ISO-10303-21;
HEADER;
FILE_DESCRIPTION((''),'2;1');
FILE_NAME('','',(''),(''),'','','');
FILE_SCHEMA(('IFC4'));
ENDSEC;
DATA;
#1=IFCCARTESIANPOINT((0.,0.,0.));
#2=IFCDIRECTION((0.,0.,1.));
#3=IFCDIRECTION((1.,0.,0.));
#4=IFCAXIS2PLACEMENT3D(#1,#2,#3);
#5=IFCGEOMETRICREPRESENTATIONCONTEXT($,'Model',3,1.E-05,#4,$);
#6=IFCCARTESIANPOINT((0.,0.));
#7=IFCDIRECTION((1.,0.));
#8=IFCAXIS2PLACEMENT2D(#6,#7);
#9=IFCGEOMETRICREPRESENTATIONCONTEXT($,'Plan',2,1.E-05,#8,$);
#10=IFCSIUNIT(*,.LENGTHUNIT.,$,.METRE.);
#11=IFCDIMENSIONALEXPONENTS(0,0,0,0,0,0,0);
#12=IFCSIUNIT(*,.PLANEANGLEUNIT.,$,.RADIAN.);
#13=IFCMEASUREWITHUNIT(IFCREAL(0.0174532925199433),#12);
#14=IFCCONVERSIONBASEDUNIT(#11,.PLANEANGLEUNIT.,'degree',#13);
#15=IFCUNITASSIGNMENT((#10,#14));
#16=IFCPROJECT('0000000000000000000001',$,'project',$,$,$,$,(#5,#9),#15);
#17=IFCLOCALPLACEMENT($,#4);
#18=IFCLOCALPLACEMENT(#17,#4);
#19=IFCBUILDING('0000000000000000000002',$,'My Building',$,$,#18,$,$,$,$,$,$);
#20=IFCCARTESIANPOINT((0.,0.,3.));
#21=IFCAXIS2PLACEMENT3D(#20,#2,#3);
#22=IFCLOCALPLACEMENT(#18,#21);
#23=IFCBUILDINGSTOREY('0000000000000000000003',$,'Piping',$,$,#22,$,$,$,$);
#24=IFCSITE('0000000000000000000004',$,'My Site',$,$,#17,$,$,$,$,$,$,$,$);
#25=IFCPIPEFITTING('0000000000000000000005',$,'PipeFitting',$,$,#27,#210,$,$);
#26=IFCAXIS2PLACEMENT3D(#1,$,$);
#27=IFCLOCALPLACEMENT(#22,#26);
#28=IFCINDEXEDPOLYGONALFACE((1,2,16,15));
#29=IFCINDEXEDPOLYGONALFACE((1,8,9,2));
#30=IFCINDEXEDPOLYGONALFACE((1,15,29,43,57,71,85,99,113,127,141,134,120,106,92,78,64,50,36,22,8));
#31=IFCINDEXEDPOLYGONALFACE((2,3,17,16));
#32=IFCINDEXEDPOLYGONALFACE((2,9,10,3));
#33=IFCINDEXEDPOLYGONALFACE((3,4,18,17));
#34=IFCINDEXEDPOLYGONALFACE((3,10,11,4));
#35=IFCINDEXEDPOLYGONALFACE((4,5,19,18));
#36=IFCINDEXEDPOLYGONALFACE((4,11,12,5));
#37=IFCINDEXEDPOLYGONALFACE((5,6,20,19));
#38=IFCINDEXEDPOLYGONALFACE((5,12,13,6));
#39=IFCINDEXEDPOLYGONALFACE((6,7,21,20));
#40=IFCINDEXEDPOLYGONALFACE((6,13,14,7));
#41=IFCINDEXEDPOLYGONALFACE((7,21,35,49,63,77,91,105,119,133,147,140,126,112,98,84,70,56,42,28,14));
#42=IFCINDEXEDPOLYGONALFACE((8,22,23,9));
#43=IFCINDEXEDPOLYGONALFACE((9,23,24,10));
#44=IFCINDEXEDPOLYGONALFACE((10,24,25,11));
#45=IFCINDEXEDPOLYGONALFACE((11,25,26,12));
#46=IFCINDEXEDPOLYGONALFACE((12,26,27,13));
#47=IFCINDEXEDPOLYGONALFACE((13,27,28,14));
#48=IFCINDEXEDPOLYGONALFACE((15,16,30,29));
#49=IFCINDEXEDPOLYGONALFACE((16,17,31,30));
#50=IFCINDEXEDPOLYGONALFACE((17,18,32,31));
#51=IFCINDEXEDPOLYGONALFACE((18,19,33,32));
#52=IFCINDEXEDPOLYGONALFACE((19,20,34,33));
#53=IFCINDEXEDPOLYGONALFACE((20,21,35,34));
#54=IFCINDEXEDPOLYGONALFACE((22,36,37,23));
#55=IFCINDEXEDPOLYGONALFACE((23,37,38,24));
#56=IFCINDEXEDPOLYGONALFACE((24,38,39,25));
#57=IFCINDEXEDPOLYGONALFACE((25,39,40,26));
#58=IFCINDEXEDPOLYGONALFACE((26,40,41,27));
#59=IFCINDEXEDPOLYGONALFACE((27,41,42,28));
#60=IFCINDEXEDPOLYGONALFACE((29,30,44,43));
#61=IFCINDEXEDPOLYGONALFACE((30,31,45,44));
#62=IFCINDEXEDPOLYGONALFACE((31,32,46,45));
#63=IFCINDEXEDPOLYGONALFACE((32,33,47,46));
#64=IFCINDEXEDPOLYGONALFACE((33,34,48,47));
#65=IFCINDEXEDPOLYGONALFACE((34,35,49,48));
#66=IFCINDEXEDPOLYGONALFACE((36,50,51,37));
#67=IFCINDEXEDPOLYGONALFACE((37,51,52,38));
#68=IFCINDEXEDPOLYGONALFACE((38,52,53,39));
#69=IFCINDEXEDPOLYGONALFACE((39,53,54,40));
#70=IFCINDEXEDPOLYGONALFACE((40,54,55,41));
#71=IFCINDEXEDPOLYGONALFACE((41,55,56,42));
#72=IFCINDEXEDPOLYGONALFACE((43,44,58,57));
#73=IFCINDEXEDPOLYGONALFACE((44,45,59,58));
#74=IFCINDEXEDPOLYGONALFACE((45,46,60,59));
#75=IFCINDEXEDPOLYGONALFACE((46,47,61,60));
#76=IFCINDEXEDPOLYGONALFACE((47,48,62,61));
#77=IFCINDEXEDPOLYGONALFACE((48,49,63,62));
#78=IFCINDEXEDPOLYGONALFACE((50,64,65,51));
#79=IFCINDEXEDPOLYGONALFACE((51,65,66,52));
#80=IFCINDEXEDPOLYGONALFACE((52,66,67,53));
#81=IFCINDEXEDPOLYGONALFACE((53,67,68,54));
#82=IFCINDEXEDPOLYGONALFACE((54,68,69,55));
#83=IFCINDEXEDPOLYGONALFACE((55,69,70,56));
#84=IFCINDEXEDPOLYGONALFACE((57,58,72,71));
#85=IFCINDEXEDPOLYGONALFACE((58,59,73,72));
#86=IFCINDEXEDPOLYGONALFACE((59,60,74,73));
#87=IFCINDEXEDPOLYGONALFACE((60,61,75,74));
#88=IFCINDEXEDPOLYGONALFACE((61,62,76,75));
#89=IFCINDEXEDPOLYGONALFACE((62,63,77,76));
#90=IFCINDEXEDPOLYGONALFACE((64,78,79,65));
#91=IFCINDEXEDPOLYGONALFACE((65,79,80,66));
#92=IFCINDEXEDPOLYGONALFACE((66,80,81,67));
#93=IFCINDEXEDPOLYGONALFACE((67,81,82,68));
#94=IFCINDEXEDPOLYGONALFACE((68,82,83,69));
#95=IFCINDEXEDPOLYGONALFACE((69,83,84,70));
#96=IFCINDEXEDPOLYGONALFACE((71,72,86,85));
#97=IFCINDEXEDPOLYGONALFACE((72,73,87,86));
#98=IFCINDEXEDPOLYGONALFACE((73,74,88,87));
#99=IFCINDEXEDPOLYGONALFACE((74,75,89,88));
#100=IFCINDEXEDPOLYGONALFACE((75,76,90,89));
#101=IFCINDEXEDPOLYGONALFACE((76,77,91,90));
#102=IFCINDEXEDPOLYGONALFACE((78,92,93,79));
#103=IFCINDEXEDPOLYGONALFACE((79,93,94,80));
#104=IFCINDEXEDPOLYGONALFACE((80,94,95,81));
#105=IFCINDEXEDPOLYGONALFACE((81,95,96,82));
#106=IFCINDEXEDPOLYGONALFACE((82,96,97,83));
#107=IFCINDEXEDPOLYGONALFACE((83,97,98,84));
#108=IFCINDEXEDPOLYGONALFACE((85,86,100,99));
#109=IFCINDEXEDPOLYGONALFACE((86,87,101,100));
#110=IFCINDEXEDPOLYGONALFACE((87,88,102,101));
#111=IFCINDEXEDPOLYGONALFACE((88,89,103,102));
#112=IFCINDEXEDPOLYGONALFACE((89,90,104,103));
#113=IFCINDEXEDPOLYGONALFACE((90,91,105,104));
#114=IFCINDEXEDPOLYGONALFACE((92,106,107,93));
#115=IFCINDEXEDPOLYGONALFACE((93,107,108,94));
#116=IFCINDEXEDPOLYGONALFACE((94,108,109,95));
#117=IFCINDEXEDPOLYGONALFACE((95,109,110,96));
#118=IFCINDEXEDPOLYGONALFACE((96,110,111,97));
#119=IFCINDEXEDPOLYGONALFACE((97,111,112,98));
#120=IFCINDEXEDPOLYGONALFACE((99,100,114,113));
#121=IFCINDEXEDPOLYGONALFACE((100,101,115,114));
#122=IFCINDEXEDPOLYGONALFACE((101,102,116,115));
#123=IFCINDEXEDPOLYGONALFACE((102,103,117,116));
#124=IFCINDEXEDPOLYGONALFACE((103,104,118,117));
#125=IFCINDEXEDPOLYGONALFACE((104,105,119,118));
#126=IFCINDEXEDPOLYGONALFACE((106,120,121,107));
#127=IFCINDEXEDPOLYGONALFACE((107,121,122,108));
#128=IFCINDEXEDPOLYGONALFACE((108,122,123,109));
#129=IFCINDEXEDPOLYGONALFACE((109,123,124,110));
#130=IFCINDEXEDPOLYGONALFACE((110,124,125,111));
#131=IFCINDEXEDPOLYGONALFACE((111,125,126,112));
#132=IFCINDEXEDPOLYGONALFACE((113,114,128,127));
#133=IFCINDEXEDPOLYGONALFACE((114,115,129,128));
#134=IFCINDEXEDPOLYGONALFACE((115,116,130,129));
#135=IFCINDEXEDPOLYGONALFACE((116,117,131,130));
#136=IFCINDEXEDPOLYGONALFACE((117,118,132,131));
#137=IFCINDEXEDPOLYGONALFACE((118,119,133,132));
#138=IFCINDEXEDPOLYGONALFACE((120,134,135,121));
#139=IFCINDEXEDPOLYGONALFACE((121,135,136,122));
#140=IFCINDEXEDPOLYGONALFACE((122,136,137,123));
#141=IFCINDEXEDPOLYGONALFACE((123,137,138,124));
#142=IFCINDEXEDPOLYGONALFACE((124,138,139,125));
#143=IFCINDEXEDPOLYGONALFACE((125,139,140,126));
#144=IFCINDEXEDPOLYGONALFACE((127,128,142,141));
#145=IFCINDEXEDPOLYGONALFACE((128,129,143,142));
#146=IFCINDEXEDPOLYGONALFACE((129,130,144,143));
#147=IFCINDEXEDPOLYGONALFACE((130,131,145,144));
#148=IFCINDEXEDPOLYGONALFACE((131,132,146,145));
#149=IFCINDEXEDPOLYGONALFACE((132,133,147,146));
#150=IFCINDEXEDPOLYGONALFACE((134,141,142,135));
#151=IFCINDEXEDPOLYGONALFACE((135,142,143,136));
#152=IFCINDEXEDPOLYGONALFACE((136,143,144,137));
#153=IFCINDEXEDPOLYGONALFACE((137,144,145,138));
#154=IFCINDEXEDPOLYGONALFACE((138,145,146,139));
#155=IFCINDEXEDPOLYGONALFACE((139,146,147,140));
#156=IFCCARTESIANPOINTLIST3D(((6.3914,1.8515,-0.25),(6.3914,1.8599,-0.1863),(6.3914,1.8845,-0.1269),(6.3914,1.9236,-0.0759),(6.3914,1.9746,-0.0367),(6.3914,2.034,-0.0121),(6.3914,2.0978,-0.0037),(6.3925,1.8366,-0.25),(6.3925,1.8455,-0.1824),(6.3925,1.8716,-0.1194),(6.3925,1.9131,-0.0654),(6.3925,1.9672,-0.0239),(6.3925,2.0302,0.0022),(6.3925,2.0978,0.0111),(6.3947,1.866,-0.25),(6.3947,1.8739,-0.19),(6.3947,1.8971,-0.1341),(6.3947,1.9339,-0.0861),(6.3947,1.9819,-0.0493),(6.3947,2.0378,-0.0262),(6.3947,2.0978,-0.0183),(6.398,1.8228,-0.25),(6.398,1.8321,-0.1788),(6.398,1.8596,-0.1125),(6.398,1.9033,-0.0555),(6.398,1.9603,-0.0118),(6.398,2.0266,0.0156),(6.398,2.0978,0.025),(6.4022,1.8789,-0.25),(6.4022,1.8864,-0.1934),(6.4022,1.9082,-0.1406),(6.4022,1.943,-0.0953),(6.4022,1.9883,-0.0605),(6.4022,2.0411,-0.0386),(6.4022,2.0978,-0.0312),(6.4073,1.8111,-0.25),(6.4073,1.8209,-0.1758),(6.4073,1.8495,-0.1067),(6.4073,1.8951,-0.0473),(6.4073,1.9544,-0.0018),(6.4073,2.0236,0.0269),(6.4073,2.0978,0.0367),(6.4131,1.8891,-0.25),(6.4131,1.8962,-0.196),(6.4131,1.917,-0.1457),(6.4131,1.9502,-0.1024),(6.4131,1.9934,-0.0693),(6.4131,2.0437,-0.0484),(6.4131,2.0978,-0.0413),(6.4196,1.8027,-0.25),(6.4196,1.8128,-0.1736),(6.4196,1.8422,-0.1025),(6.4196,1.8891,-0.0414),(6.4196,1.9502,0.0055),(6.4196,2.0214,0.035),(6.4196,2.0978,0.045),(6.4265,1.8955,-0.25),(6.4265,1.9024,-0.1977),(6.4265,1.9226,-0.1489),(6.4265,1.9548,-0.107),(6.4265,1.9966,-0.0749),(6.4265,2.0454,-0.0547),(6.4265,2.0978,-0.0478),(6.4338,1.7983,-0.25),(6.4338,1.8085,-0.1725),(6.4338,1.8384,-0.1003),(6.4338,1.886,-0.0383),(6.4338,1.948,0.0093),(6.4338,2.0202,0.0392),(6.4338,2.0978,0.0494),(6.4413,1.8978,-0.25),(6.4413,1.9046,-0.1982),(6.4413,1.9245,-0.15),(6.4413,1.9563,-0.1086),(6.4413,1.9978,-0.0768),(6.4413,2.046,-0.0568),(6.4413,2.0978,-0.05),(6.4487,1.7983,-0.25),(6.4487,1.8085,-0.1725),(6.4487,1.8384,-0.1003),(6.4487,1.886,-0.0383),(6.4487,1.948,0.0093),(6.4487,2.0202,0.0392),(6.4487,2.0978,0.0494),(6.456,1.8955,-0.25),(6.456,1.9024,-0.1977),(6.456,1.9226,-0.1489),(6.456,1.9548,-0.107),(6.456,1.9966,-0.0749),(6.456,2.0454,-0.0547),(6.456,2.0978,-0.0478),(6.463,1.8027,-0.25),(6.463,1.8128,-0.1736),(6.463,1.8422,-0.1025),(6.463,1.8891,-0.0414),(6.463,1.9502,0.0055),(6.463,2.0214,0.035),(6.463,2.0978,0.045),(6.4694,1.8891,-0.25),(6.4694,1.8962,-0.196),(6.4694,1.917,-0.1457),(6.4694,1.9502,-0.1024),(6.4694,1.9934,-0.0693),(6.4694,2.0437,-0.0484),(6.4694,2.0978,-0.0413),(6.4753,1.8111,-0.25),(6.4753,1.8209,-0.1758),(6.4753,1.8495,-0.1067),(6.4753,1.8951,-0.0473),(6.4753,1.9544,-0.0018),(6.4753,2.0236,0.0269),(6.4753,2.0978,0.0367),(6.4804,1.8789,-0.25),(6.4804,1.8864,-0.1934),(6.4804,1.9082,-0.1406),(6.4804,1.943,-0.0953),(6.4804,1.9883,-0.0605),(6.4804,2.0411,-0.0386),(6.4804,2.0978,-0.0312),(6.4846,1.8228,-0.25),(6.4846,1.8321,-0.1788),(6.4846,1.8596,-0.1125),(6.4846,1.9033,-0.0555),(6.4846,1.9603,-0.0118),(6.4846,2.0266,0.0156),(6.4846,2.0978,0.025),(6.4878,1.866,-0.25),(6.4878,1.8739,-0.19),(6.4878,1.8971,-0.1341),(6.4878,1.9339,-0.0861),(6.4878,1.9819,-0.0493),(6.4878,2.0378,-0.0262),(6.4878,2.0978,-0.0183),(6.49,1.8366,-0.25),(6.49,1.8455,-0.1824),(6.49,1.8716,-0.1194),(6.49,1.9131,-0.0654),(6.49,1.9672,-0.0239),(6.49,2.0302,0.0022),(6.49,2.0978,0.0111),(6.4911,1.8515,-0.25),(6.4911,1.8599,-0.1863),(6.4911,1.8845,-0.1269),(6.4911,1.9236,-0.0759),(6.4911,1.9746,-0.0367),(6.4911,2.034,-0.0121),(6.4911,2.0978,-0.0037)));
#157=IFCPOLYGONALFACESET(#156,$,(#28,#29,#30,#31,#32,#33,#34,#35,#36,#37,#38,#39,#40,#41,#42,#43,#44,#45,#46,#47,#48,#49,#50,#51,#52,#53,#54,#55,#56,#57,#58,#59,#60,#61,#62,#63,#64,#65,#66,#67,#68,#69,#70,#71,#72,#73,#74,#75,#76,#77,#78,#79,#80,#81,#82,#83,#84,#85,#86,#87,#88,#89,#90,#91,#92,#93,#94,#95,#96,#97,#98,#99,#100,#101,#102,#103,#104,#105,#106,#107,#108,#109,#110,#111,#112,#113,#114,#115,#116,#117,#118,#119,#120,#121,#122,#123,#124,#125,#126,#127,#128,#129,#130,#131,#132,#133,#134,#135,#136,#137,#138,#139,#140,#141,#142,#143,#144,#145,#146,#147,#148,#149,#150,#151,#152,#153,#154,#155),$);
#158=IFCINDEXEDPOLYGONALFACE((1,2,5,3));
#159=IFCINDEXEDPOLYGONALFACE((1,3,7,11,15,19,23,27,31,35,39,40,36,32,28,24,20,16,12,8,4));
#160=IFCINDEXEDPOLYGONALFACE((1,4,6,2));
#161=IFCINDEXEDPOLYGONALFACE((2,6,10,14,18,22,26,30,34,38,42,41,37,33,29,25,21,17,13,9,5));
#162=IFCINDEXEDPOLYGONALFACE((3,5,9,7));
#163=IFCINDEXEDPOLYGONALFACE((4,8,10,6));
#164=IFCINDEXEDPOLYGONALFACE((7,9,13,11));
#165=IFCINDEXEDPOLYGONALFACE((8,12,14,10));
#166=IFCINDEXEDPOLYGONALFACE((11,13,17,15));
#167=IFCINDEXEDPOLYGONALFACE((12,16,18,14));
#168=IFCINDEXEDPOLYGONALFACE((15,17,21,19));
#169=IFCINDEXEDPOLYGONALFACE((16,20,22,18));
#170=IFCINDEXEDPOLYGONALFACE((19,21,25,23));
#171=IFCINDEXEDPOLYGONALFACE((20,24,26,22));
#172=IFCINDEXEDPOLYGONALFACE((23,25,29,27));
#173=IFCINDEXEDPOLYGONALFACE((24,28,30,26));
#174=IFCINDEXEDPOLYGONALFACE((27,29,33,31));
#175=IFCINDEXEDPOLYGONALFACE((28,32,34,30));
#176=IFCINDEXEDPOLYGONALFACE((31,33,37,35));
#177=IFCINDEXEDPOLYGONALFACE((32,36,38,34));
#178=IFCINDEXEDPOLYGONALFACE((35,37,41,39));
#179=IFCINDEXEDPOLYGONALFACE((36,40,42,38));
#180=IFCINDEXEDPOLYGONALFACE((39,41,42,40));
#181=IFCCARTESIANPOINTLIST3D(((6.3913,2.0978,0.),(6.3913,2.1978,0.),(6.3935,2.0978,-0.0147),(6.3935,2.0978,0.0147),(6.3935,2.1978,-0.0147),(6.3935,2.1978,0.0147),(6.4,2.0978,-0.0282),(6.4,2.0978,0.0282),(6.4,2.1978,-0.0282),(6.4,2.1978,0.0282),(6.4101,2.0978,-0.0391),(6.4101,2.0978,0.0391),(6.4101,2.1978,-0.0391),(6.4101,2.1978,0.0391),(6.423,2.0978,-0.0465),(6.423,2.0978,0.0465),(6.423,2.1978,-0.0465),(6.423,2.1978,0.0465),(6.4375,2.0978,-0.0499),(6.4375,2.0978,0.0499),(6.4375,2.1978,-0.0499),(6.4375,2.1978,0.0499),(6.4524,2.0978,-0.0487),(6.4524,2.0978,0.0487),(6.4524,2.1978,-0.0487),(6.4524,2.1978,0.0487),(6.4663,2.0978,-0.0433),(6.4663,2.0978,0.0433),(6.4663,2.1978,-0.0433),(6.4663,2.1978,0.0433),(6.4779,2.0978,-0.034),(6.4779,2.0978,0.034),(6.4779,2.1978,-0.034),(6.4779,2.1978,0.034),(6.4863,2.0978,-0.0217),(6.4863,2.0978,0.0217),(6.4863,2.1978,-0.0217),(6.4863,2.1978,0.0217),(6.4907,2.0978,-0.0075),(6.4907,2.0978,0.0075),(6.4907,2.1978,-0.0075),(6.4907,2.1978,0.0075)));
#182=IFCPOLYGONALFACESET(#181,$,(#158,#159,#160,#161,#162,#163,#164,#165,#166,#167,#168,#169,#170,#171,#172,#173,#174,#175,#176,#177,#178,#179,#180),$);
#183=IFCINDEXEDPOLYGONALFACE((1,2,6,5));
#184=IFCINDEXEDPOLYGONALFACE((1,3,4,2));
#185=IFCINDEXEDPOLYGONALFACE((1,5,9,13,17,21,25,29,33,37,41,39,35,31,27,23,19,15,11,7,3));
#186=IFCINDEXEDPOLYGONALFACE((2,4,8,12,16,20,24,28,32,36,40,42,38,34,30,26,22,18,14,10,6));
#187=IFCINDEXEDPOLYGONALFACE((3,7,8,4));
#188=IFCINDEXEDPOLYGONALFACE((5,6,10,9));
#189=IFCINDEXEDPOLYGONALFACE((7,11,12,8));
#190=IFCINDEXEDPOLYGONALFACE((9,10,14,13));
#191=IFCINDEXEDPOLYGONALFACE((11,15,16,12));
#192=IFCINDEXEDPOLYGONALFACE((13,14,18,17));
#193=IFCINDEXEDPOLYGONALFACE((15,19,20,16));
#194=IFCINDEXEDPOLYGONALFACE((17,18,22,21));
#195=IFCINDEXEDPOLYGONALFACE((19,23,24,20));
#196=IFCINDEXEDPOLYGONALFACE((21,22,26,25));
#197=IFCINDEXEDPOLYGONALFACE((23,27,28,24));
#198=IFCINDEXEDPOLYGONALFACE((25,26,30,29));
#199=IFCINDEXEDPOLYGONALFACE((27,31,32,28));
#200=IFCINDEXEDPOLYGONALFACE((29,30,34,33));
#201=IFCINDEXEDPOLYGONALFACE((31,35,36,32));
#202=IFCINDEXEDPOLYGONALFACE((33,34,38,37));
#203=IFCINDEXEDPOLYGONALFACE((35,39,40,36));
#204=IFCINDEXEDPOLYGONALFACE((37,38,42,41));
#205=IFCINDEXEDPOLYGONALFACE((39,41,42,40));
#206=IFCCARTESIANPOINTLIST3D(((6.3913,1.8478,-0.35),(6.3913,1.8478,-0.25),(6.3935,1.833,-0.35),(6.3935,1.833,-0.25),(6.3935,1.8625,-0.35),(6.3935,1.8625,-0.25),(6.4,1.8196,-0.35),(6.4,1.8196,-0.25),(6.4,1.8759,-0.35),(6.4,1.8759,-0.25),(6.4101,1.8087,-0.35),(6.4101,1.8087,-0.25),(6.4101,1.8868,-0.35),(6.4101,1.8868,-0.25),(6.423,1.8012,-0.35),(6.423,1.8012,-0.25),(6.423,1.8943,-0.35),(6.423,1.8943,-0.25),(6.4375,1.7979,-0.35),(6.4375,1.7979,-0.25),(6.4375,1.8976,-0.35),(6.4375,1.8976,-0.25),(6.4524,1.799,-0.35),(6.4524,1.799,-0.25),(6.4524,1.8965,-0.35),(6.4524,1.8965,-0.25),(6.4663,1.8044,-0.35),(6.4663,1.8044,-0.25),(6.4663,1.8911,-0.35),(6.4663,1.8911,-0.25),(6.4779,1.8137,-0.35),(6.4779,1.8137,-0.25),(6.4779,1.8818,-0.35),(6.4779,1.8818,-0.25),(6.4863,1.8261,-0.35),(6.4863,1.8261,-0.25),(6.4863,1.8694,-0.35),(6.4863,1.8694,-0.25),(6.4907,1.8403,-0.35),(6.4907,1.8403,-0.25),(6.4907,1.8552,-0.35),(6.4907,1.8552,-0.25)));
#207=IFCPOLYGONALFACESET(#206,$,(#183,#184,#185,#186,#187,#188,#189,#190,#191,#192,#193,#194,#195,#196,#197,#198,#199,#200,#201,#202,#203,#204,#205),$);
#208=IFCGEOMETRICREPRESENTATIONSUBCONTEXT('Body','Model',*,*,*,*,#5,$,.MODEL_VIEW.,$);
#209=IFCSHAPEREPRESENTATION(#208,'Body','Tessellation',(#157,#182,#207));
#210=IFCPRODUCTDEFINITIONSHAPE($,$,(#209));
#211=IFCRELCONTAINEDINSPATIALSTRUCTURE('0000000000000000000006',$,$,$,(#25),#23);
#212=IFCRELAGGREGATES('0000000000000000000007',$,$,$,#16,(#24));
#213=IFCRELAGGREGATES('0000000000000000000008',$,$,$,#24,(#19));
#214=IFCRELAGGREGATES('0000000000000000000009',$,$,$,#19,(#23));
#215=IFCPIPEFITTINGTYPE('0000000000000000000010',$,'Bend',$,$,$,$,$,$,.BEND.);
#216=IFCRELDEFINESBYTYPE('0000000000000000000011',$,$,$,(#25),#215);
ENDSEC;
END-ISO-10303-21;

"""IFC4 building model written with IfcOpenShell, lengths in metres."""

from ifc_helpers import new_model, entity, si_unit, converted_unit, frame, origin_with_axes, origin_2d_with_axis, place, context, subcontext, project, spatial, circle, extrude, source, transform, mapped, type_object, type_shapes, element, save


model = new_model("IFC4")

# Units and contexts
model_context = context("Model", 3, precision=1e-05, world=origin_with_axes())
plan_context = context("Plan", 2, precision=1e-05, world=origin_2d_with_axis())
body_context = subcontext(model_context, "Body", "Model", "MODEL_VIEW")
ifc_project = project(units=[si_unit("LENGTHUNIT", "METRE"), converted_unit("PLANEANGLEUNIT", "degree", entity("IfcReal", 0.0174532925199433), si_unit("PLANEANGLEUNIT", "RADIAN"), dimensions=[0, 0, 0, 0, 0, 0, 0])], contexts=[model_context, plan_context])

# Site, building, storey
site_placement = place(None, origin_with_axes())
site = spatial("IfcSite", under=ifc_project, at=site_placement, Name="My Site")
building_placement = place(site_placement, origin_with_axes())
building = spatial("IfcBuilding", under=site, at=building_placement, Name="My Building")
storey_placement = place(building_placement, frame((0.0, 0.0, 3.0), z_axis=(0.0, 0.0, 1.0), x_axis=(1.0, 0.0, 0.0)))
storey = spatial("IfcBuildingStorey", under=building, at=storey_placement, Name="Piping")

# Pipe fitting
pipe_fitting_type = type_object("IfcPipeFittingType", Name="Bend", PredefinedType="BEND")
shared_shape = source(origin_with_axes(), body_context, "Body", "SolidModel", [
    entity("IfcSweptDiskSolid", entity("IfcIndexedPolyCurve", entity("IfcCartesianPointList3D", [[0.0, 0.0, -0.1], [0.0, -0.0732, -0.2768], [0.0, -0.25, -0.35]]), [entity("IfcArcIndex", [1, 2, 3])]), 0.05),
    extrude(circle(Radius=0.05), origin_with_axes(), (0.0, 0.0, -1.0), 0.1),
    extrude(circle(Radius=0.05), frame((0.0, -0.25, -0.35), z_axis=(0.0, -1.0, 0.0), x_axis=(1.0, 0.0, 0.0)), (0.0, 0.0, 1.0), 0.1),
])
type_shapes(pipe_fitting_type, [shared_shape])
for number, where, z_axis, x_axis, name in (
    (1, (6.4413, 2.1978, 0.0), (0.0, 1.0, 0.0), (-1.0, 0.0, 0.0), "PipeFitting"),
):
    element("IfcPipeFitting", number, at=place(storey_placement, frame(where, z_axis=z_axis, x_axis=x_axis)), inside=storey, type_object=pipe_fitting_type, Name=name, context=body_context, shape_type="MappedRepresentation", body=[
        mapped(shared_shape, transform((0.0, 0.0, 0.0), x_axis=(1.0, 0.0, 0.0), y_axis=(0.0, 1.0, 0.0), z_axis=(0.0, 0.0, 1.0), scale=1.0)),
    ])

save(model, "model.ifc")
